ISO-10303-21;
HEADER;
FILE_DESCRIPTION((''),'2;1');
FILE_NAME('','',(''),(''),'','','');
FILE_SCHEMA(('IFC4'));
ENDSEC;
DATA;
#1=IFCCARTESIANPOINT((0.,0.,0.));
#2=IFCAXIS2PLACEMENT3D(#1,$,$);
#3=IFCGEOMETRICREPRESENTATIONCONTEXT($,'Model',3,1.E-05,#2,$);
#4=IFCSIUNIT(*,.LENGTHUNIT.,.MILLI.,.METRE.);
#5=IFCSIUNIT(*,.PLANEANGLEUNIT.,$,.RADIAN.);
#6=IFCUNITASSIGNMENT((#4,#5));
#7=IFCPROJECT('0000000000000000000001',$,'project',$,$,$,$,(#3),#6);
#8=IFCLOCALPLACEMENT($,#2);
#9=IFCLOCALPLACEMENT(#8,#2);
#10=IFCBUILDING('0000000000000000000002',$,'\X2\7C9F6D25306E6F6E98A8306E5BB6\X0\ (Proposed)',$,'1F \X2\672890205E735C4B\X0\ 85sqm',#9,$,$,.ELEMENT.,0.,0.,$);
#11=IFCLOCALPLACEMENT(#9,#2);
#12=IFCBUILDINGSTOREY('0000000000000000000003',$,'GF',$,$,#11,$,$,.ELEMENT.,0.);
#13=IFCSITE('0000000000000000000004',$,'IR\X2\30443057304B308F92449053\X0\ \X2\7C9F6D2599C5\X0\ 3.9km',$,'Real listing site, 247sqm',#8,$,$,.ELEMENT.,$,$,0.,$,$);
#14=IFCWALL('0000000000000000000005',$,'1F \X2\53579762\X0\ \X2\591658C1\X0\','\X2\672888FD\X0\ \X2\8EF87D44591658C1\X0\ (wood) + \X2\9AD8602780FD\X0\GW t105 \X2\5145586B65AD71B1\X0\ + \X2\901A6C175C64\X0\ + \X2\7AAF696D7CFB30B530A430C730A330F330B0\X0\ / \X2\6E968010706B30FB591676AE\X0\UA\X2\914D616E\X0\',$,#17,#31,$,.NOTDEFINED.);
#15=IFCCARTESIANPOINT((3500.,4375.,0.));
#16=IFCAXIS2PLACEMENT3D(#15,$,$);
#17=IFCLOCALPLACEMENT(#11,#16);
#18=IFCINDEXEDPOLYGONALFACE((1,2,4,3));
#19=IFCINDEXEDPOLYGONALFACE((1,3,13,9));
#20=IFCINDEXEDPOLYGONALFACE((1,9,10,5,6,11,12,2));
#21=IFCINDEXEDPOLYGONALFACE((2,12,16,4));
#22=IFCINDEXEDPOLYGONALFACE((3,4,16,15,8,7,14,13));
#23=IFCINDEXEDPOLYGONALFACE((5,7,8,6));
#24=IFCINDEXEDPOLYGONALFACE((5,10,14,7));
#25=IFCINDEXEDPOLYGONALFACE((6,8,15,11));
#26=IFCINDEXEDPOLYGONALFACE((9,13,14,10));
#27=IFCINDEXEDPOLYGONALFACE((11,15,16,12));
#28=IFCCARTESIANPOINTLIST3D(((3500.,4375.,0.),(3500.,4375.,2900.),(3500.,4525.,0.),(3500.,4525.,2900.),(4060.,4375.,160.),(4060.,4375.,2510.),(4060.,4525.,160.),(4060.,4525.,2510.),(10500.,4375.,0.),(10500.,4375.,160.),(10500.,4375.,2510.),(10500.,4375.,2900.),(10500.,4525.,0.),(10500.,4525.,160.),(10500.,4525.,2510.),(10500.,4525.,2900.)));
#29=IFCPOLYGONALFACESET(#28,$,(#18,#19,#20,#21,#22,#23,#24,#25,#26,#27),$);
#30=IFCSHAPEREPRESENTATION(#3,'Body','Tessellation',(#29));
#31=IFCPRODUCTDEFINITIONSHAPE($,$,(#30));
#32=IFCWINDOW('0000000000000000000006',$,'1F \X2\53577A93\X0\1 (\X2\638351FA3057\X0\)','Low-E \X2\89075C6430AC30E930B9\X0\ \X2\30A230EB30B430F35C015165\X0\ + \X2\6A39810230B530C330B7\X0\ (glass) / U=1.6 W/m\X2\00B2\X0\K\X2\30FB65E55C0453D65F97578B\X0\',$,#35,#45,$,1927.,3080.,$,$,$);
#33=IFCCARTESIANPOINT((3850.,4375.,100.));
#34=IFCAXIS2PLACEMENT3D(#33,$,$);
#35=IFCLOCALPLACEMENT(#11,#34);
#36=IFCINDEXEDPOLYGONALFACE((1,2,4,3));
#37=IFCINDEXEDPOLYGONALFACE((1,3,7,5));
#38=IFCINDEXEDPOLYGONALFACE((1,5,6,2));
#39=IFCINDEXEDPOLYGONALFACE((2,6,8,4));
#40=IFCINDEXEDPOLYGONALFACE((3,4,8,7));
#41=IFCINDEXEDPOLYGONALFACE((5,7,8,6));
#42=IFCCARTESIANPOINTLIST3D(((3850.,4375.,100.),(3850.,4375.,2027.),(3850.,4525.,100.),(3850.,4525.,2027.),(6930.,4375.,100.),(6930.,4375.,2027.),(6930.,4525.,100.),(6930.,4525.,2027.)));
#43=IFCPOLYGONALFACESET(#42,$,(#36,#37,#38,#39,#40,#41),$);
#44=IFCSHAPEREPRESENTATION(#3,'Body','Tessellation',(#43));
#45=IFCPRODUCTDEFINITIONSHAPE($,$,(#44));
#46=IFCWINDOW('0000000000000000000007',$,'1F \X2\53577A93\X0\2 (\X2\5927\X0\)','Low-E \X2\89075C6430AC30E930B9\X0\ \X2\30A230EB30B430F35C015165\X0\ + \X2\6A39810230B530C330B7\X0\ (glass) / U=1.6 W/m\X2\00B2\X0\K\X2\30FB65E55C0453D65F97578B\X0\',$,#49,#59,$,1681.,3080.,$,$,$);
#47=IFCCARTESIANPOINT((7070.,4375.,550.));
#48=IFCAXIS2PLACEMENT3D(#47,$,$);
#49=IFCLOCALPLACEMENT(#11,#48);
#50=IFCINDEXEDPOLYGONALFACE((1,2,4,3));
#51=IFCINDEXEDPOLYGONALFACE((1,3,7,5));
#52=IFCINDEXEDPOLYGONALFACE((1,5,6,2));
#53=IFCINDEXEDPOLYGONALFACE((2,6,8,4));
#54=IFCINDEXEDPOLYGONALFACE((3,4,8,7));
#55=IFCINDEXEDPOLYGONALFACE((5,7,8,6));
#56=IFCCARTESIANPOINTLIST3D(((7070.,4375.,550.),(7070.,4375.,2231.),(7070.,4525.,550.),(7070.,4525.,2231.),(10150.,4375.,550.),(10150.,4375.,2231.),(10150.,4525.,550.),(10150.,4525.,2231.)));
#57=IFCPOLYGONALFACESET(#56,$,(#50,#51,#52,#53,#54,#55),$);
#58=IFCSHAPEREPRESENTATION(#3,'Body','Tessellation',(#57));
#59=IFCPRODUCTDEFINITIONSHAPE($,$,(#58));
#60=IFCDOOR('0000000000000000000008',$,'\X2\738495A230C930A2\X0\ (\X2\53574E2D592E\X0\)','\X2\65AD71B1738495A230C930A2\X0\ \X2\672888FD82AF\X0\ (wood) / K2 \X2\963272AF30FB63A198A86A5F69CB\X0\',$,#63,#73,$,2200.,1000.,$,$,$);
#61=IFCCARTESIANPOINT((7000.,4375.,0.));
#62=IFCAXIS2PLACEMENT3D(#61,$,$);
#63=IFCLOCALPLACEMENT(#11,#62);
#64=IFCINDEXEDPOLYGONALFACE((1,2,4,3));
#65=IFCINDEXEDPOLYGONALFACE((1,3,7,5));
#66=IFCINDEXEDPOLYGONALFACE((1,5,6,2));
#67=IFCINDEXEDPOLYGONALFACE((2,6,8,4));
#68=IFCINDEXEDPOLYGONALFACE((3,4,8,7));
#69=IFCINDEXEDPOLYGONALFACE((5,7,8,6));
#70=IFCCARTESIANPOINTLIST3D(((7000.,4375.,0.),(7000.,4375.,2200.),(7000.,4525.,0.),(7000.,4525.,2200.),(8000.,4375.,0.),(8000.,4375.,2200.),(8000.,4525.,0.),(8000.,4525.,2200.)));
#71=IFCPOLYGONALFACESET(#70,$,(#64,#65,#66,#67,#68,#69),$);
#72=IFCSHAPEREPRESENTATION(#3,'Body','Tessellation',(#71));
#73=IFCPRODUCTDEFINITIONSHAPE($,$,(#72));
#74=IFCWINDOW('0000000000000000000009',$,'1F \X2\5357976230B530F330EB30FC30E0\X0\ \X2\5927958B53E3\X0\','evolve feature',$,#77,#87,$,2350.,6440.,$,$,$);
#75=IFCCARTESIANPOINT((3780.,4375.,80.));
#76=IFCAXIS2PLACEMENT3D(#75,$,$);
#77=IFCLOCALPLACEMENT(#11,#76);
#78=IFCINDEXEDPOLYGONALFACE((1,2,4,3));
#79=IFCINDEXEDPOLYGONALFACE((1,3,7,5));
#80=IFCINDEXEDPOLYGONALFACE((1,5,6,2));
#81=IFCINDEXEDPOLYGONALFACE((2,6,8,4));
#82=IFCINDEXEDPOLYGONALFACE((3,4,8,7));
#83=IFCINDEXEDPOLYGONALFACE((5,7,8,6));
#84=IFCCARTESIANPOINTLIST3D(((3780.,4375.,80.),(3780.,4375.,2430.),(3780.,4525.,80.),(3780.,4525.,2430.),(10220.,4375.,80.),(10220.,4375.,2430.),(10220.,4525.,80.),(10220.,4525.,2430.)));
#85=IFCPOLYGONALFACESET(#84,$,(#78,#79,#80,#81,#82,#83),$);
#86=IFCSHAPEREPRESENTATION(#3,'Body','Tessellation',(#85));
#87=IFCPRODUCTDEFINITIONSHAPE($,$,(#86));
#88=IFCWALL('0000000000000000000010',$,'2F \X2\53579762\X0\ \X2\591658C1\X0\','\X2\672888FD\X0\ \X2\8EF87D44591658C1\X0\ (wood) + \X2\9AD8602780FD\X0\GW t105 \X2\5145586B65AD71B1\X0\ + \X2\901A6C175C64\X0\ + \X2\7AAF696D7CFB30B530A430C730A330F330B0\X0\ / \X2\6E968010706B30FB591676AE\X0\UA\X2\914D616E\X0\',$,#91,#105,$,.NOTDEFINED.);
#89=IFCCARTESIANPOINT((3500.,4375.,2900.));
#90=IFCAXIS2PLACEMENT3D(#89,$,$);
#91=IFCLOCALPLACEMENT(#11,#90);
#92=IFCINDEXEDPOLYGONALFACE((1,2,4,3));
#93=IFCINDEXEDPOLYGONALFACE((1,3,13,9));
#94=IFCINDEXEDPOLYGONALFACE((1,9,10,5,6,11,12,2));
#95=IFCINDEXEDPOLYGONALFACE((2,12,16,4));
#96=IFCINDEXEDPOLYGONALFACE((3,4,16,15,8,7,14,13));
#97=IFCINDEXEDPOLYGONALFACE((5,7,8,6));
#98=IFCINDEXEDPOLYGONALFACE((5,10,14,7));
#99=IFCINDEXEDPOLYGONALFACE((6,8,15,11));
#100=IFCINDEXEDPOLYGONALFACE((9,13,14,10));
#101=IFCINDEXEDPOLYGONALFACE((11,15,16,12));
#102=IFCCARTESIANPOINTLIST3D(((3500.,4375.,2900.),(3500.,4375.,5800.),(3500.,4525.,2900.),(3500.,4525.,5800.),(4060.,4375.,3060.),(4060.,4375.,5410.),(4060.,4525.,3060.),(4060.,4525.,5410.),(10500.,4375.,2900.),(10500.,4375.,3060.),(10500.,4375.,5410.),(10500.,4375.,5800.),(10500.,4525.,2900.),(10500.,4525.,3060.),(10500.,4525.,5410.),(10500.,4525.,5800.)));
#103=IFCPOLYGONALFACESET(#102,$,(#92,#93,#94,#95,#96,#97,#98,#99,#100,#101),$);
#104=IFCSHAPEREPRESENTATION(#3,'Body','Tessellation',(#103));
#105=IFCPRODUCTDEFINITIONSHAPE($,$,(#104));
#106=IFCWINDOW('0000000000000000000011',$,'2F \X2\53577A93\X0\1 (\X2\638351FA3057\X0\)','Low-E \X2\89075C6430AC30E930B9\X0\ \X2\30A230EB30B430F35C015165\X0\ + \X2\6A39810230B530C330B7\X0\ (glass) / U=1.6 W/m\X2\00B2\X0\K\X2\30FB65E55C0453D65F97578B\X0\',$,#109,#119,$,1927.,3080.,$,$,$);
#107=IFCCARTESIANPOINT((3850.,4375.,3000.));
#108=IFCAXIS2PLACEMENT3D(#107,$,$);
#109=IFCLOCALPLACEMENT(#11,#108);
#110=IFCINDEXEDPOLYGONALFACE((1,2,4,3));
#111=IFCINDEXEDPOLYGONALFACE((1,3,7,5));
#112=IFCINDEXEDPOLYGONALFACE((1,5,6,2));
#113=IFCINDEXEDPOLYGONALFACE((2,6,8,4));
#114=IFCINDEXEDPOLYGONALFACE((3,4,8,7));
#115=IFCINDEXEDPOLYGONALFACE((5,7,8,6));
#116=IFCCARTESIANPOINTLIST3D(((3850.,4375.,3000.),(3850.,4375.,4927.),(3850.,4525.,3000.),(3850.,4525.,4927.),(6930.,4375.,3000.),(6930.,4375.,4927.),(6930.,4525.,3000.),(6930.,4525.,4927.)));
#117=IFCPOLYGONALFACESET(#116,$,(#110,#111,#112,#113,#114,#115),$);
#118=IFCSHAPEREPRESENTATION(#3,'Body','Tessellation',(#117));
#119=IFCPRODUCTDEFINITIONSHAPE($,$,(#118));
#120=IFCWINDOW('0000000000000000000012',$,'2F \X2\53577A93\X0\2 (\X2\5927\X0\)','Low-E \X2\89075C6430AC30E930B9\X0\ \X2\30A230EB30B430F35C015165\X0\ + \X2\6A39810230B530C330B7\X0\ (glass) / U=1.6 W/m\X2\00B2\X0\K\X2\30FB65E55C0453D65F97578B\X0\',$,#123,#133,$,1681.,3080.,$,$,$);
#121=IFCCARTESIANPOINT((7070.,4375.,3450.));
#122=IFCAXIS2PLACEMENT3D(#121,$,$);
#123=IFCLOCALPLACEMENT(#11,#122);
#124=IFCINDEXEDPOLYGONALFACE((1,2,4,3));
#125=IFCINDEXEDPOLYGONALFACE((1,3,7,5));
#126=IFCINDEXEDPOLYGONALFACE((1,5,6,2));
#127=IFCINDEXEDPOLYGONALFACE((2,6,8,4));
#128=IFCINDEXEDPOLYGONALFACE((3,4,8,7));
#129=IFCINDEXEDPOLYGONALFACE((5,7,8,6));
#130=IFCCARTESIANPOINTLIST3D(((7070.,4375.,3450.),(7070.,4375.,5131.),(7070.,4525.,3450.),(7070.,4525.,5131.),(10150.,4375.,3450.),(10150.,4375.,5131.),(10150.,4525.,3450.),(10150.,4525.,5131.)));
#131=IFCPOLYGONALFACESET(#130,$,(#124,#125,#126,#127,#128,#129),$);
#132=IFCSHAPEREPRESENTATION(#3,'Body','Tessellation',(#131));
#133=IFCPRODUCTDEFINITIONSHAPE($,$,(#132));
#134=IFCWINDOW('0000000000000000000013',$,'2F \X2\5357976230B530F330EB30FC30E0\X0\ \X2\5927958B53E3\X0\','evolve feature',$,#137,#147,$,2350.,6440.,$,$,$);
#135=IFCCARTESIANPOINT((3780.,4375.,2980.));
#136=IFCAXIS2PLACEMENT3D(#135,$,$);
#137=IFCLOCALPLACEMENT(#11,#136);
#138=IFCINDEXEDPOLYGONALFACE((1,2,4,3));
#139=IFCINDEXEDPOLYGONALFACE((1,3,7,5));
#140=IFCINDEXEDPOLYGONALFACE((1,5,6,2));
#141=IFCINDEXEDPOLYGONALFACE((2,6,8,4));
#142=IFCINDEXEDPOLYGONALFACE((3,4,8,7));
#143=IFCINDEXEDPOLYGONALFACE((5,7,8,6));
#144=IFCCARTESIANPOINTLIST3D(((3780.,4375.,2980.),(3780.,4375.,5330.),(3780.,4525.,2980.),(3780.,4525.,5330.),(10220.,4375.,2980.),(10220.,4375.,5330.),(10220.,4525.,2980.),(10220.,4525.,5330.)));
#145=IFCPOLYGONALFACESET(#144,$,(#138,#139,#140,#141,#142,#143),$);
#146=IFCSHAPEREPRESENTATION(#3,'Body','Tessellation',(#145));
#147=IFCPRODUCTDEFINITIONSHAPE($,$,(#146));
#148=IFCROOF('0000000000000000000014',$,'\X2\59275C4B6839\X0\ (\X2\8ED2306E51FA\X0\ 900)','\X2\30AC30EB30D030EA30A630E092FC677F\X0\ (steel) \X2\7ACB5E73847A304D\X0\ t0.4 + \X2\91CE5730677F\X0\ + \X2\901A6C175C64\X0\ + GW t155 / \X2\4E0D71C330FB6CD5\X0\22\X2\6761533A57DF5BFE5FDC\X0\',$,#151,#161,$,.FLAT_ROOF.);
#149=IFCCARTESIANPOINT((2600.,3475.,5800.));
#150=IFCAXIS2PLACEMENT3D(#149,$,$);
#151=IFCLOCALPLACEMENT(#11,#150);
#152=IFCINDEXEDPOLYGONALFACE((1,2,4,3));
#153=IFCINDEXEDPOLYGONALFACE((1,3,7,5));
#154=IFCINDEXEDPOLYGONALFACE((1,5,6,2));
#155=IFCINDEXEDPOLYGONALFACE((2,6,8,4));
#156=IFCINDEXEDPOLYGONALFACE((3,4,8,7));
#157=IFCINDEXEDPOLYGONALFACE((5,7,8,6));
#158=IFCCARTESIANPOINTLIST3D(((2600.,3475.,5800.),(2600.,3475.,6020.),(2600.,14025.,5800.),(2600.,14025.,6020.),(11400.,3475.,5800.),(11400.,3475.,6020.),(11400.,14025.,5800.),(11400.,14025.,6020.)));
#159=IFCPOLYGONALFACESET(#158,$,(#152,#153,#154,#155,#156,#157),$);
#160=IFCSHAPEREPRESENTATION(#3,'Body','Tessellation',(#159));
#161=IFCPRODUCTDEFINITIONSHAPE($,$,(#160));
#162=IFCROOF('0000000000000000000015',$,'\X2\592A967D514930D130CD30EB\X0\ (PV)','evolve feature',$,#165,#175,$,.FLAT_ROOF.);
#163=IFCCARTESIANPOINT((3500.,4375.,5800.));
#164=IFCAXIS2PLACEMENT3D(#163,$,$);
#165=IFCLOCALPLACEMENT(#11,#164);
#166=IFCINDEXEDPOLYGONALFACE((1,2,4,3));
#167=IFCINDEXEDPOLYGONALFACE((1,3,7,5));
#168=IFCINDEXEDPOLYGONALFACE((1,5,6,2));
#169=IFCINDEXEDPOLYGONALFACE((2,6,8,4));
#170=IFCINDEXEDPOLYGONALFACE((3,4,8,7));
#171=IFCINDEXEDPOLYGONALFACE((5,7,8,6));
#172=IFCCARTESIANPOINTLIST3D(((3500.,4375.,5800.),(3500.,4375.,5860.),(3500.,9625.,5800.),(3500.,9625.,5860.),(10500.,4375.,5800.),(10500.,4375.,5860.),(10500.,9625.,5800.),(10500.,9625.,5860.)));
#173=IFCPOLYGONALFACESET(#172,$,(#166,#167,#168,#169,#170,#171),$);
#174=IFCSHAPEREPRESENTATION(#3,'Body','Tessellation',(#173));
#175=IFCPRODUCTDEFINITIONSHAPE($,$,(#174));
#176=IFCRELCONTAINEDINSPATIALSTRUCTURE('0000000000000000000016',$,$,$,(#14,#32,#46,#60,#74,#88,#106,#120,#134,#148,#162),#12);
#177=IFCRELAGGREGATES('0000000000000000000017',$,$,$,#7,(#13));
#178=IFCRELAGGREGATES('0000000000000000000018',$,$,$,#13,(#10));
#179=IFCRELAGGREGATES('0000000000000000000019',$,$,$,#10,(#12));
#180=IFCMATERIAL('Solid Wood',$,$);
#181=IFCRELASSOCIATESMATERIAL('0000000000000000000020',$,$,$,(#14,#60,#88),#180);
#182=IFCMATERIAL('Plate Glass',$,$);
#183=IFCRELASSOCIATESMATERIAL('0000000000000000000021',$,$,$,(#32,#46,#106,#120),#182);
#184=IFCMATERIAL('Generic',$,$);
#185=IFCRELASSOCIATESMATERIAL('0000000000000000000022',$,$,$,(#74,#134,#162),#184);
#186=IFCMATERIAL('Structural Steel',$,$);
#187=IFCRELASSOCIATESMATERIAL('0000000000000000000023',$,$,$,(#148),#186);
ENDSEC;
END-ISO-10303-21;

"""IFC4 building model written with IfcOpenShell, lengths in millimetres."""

from ifc_helpers import new_model, si_unit, frame, frame_2d, origin, place, context, project, spatial, rectangle, extrude, material, element, fill, save


model = new_model("IFC4")

# Units and contexts
model_context = context("Model", 3, precision=1e-05, world=origin())
ifc_project = project(units=[si_unit("LENGTHUNIT", "METRE", prefix="MILLI"), si_unit("PLANEANGLEUNIT", "RADIAN")], contexts=[model_context])

# Site, building, storey
site_placement = place(None, origin())
site = spatial("IfcSite", under=ifc_project, at=site_placement, Name="IRいしかわ鉄道 粟津駅 3.9km", ObjectType="Real listing site, 247sqm", CompositionType="ELEMENT", RefElevation=0.0)
building_placement = place(site_placement, origin())
building = spatial("IfcBuilding", under=site, at=building_placement, Name="粟津の潮風の家 (Proposed)", ObjectType="1F 木造平屋 85sqm", CompositionType="ELEMENT", ElevationOfRefHeight=0.0, ElevationOfTerrain=0.0)
storey_placement = place(building_placement, origin())
storey = spatial("IfcBuildingStorey", under=building, at=storey_placement, Name="GF", CompositionType="ELEMENT", Elevation=0.0)

# Shared definitions
ifc_material_1 = material(Name="Solid Wood")
ifc_material_2 = material(Name="Generic")

# Wall, openings, windows, door
wall_1_placement = place(storey_placement, frame((3500.0, 4375.0, 0.0)))
wall_1 = element("IfcWall", 1, at=wall_1_placement, inside=storey, material=ifc_material_1, Name="1F 南面 外壁", Description="木製 軸組外壁 (wood) + 高性能GW t105 充填断熱 + 通気層 + 窯業系サイディング / 準耐火・外皮UA配慮", PredefinedType="NOTDEFINED", context=model_context, shape_type="SweptSolid", body=[
    extrude(rectangle(XDim=7000.0, YDim=150.0, at=frame_2d((3500.0, 75.0))), frame((3500.0, 4375.0, 0.0)), (0.0, 0.0, 1.0), 2900.0),
])
opening_1_placement = place(storey_placement, frame((3850.0, 4375.0, 100.0)))
opening_1 = element("IfcOpeningElement", 2, at=opening_1_placement, cuts=wall_1, PredefinedType="NOTDEFINED", context=model_context, shape_type="SweptSolid", body=[
    extrude(rectangle(XDim=3080.0, YDim=150.0, at=frame_2d((1540.0, 75.0))), frame((3850.0, 4375.0, 100.0)), (0.0, 0.0, 1.0), 1927.0),
])
opening_2_placement = place(storey_placement, frame((7070.0, 4375.0, 550.0)))
opening_2 = element("IfcOpeningElement", 3, at=opening_2_placement, cuts=wall_1, PredefinedType="NOTDEFINED", context=model_context, shape_type="SweptSolid", body=[
    extrude(rectangle(XDim=3080.0, YDim=150.0, at=frame_2d((1540.0, 75.0))), frame((7070.0, 4375.0, 550.0)), (0.0, 0.0, 1.0), 1681.0),
])
opening_3_placement = place(storey_placement, frame((7000.0, 4375.0, 0.0)))
opening_3 = element("IfcOpeningElement", 4, at=opening_3_placement, cuts=wall_1, PredefinedType="NOTDEFINED", context=model_context, shape_type="SweptSolid", body=[
    extrude(rectangle(XDim=1000.0, YDim=150.0, at=frame_2d((500.0, 75.0))), frame((7000.0, 4375.0, 0.0)), (0.0, 0.0, 1.0), 2200.0),
])
opening_4_placement = place(storey_placement, frame((3780.0, 4375.0, 80.0)))
opening_4 = element("IfcOpeningElement", 5, at=opening_4_placement, cuts=wall_1, PredefinedType="NOTDEFINED", context=model_context, shape_type="SweptSolid", body=[
    extrude(rectangle(XDim=6440.0, YDim=150.0, at=frame_2d((3220.0, 75.0))), frame((3780.0, 4375.0, 80.0)), (0.0, 0.0, 1.0), 2350.0),
])
ifc_material_3 = material(Name="Plate Glass")
window_1_placement = place(storey_placement, frame((3850.0, 4375.0, 100.0)))
window_1 = element("IfcWindow", 6, at=window_1_placement, inside=storey, material=ifc_material_3, Name="1F 南窓1 (掃出し)", Description="Low-E 複層ガラス アルゴン封入 + 樹脂サッシ (glass) / U=1.6 W/m²K・日射取得型", OverallHeight=1927.0, OverallWidth=3080.0, context=model_context, shape_type="SweptSolid", body=[
    extrude(rectangle(XDim=3080.0, YDim=150.0, at=frame_2d((1540.0, 75.0))), frame((3850.0, 4375.0, 100.0)), (0.0, 0.0, 1.0), 1927.0),
])
fill(opening_1, window_1)
window_2_placement = place(storey_placement, frame((7070.0, 4375.0, 550.0)))
window_2 = element("IfcWindow", 7, at=window_2_placement, inside=storey, material=ifc_material_3, Name="1F 南窓2 (大)", Description="Low-E 複層ガラス アルゴン封入 + 樹脂サッシ (glass) / U=1.6 W/m²K・日射取得型", OverallHeight=1681.0, OverallWidth=3080.0, context=model_context, shape_type="SweptSolid", body=[
    extrude(rectangle(XDim=3080.0, YDim=150.0, at=frame_2d((1540.0, 75.0))), frame((7070.0, 4375.0, 550.0)), (0.0, 0.0, 1.0), 1681.0),
])
fill(opening_2, window_2)
door_placement = place(storey_placement, frame((7000.0, 4375.0, 0.0)))
door = element("IfcDoor", 8, at=door_placement, inside=storey, material=ifc_material_1, Name="玄関ドア (南中央)", Description="断熱玄関ドア 木製芯 (wood) / K2 防犯・採風機構", OverallHeight=2200.0, OverallWidth=1000.0, context=model_context, shape_type="SweptSolid", body=[
    extrude(rectangle(XDim=1000.0, YDim=150.0, at=frame_2d((500.0, 75.0))), frame((7000.0, 4375.0, 0.0)), (0.0, 0.0, 1.0), 2200.0),
])
fill(opening_3, door)
window_3_placement = place(storey_placement, frame((3780.0, 4375.0, 80.0)))
window_3 = element("IfcWindow", 9, at=window_3_placement, inside=storey, material=ifc_material_2, Name="1F 南面サンルーム 大開口", Description="evolve feature", OverallHeight=2350.0, OverallWidth=6440.0, context=model_context, shape_type="SweptSolid", body=[
    extrude(rectangle(XDim=6440.0, YDim=150.0, at=frame_2d((3220.0, 75.0))), frame((3780.0, 4375.0, 80.0)), (0.0, 0.0, 1.0), 2350.0),
])
fill(opening_4, window_3)

# Wall, openings, windows
wall_2_placement = place(storey_placement, frame((3500.0, 4375.0, 2900.0)))
wall_2 = element("IfcWall", 10, at=wall_2_placement, inside=storey, material=ifc_material_1, Name="2F 南面 外壁", Description="木製 軸組外壁 (wood) + 高性能GW t105 充填断熱 + 通気層 + 窯業系サイディング / 準耐火・外皮UA配慮", PredefinedType="NOTDEFINED", context=model_context, shape_type="SweptSolid", body=[
    extrude(rectangle(XDim=7000.0, YDim=150.0, at=frame_2d((3500.0, 75.0))), frame((3500.0, 4375.0, 2900.0)), (0.0, 0.0, 1.0), 2900.0),
])
opening_5_placement = place(storey_placement, frame((3850.0, 4375.0, 3000.0)))
opening_5 = element("IfcOpeningElement", 11, at=opening_5_placement, cuts=wall_2, PredefinedType="NOTDEFINED", context=model_context, shape_type="SweptSolid", body=[
    extrude(rectangle(XDim=3080.0, YDim=150.0, at=frame_2d((1540.0, 75.0))), frame((3850.0, 4375.0, 3000.0)), (0.0, 0.0, 1.0), 1927.0),
])
opening_6_placement = place(storey_placement, frame((7070.0, 4375.0, 3450.0)))
opening_6 = element("IfcOpeningElement", 12, at=opening_6_placement, cuts=wall_2, PredefinedType="NOTDEFINED", context=model_context, shape_type="SweptSolid", body=[
    extrude(rectangle(XDim=3080.0, YDim=150.0, at=frame_2d((1540.0, 75.0))), frame((7070.0, 4375.0, 3450.0)), (0.0, 0.0, 1.0), 1681.0),
])
opening_7_placement = place(storey_placement, frame((3780.0, 4375.0, 2980.0)))
opening_7 = element("IfcOpeningElement", 13, at=opening_7_placement, cuts=wall_2, PredefinedType="NOTDEFINED", context=model_context, shape_type="SweptSolid", body=[
    extrude(rectangle(XDim=6440.0, YDim=150.0, at=frame_2d((3220.0, 75.0))), frame((3780.0, 4375.0, 2980.0)), (0.0, 0.0, 1.0), 2350.0),
])
window_4_placement = place(storey_placement, frame((3850.0, 4375.0, 3000.0)))
window_4 = element("IfcWindow", 14, at=window_4_placement, inside=storey, material=ifc_material_3, Name="2F 南窓1 (掃出し)", Description="Low-E 複層ガラス アルゴン封入 + 樹脂サッシ (glass) / U=1.6 W/m²K・日射取得型", OverallHeight=1927.0, OverallWidth=3080.0, context=model_context, shape_type="SweptSolid", body=[
    extrude(rectangle(XDim=3080.0, YDim=150.0, at=frame_2d((1540.0, 75.0))), frame((3850.0, 4375.0, 3000.0)), (0.0, 0.0, 1.0), 1927.0),
])
fill(opening_5, window_4)
window_5_placement = place(storey_placement, frame((7070.0, 4375.0, 3450.0)))
window_5 = element("IfcWindow", 15, at=window_5_placement, inside=storey, material=ifc_material_3, Name="2F 南窓2 (大)", Description="Low-E 複層ガラス アルゴン封入 + 樹脂サッシ (glass) / U=1.6 W/m²K・日射取得型", OverallHeight=1681.0, OverallWidth=3080.0, context=model_context, shape_type="SweptSolid", body=[
    extrude(rectangle(XDim=3080.0, YDim=150.0, at=frame_2d((1540.0, 75.0))), frame((7070.0, 4375.0, 3450.0)), (0.0, 0.0, 1.0), 1681.0),
])
fill(opening_6, window_5)
window_6_placement = place(storey_placement, frame((3780.0, 4375.0, 2980.0)))
window_6 = element("IfcWindow", 16, at=window_6_placement, inside=storey, material=ifc_material_2, Name="2F 南面サンルーム 大開口", Description="evolve feature", OverallHeight=2350.0, OverallWidth=6440.0, context=model_context, shape_type="SweptSolid", body=[
    extrude(rectangle(XDim=6440.0, YDim=150.0, at=frame_2d((3220.0, 75.0))), frame((3780.0, 4375.0, 2980.0)), (0.0, 0.0, 1.0), 2350.0),
])
fill(opening_7, window_6)

# Roofs
ifc_material_4 = material(Name="Structural Steel")
roof_1_placement = place(storey_placement, frame((2600.0, 3475.0, 5800.0)))
element("IfcRoof", 17, at=roof_1_placement, inside=storey, material=ifc_material_4, Name="大屋根 (軒の出 900)", Description="ガルバリウム鋼板 (steel) 立平葺き t0.4 + 野地板 + 通気層 + GW t155 / 不燃・法22条区域対応", PredefinedType="FLAT_ROOF", context=model_context, shape_type="SweptSolid", body=[
    extrude(rectangle(XDim=8800.0, YDim=10550.0, at=frame_2d((4400.0, 5275.0))), frame((2600.0, 3475.0, 5800.0)), (0.0, 0.0, 1.0), 220.0),
])
roof_2_placement = place(storey_placement, frame((3500.0, 4375.0, 5800.0)))
element("IfcRoof", 18, at=roof_2_placement, inside=storey, material=ifc_material_2, Name="太陽光パネル (PV)", Description="evolve feature", PredefinedType="FLAT_ROOF", context=model_context, shape_type="SweptSolid", body=[
    extrude(rectangle(XDim=7000.0, YDim=5250.0, at=frame_2d((3500.0, 2625.0))), frame((3500.0, 4375.0, 5800.0)), (0.0, 0.0, 1.0), 60.0),
])

save(model, "model.ifc")
